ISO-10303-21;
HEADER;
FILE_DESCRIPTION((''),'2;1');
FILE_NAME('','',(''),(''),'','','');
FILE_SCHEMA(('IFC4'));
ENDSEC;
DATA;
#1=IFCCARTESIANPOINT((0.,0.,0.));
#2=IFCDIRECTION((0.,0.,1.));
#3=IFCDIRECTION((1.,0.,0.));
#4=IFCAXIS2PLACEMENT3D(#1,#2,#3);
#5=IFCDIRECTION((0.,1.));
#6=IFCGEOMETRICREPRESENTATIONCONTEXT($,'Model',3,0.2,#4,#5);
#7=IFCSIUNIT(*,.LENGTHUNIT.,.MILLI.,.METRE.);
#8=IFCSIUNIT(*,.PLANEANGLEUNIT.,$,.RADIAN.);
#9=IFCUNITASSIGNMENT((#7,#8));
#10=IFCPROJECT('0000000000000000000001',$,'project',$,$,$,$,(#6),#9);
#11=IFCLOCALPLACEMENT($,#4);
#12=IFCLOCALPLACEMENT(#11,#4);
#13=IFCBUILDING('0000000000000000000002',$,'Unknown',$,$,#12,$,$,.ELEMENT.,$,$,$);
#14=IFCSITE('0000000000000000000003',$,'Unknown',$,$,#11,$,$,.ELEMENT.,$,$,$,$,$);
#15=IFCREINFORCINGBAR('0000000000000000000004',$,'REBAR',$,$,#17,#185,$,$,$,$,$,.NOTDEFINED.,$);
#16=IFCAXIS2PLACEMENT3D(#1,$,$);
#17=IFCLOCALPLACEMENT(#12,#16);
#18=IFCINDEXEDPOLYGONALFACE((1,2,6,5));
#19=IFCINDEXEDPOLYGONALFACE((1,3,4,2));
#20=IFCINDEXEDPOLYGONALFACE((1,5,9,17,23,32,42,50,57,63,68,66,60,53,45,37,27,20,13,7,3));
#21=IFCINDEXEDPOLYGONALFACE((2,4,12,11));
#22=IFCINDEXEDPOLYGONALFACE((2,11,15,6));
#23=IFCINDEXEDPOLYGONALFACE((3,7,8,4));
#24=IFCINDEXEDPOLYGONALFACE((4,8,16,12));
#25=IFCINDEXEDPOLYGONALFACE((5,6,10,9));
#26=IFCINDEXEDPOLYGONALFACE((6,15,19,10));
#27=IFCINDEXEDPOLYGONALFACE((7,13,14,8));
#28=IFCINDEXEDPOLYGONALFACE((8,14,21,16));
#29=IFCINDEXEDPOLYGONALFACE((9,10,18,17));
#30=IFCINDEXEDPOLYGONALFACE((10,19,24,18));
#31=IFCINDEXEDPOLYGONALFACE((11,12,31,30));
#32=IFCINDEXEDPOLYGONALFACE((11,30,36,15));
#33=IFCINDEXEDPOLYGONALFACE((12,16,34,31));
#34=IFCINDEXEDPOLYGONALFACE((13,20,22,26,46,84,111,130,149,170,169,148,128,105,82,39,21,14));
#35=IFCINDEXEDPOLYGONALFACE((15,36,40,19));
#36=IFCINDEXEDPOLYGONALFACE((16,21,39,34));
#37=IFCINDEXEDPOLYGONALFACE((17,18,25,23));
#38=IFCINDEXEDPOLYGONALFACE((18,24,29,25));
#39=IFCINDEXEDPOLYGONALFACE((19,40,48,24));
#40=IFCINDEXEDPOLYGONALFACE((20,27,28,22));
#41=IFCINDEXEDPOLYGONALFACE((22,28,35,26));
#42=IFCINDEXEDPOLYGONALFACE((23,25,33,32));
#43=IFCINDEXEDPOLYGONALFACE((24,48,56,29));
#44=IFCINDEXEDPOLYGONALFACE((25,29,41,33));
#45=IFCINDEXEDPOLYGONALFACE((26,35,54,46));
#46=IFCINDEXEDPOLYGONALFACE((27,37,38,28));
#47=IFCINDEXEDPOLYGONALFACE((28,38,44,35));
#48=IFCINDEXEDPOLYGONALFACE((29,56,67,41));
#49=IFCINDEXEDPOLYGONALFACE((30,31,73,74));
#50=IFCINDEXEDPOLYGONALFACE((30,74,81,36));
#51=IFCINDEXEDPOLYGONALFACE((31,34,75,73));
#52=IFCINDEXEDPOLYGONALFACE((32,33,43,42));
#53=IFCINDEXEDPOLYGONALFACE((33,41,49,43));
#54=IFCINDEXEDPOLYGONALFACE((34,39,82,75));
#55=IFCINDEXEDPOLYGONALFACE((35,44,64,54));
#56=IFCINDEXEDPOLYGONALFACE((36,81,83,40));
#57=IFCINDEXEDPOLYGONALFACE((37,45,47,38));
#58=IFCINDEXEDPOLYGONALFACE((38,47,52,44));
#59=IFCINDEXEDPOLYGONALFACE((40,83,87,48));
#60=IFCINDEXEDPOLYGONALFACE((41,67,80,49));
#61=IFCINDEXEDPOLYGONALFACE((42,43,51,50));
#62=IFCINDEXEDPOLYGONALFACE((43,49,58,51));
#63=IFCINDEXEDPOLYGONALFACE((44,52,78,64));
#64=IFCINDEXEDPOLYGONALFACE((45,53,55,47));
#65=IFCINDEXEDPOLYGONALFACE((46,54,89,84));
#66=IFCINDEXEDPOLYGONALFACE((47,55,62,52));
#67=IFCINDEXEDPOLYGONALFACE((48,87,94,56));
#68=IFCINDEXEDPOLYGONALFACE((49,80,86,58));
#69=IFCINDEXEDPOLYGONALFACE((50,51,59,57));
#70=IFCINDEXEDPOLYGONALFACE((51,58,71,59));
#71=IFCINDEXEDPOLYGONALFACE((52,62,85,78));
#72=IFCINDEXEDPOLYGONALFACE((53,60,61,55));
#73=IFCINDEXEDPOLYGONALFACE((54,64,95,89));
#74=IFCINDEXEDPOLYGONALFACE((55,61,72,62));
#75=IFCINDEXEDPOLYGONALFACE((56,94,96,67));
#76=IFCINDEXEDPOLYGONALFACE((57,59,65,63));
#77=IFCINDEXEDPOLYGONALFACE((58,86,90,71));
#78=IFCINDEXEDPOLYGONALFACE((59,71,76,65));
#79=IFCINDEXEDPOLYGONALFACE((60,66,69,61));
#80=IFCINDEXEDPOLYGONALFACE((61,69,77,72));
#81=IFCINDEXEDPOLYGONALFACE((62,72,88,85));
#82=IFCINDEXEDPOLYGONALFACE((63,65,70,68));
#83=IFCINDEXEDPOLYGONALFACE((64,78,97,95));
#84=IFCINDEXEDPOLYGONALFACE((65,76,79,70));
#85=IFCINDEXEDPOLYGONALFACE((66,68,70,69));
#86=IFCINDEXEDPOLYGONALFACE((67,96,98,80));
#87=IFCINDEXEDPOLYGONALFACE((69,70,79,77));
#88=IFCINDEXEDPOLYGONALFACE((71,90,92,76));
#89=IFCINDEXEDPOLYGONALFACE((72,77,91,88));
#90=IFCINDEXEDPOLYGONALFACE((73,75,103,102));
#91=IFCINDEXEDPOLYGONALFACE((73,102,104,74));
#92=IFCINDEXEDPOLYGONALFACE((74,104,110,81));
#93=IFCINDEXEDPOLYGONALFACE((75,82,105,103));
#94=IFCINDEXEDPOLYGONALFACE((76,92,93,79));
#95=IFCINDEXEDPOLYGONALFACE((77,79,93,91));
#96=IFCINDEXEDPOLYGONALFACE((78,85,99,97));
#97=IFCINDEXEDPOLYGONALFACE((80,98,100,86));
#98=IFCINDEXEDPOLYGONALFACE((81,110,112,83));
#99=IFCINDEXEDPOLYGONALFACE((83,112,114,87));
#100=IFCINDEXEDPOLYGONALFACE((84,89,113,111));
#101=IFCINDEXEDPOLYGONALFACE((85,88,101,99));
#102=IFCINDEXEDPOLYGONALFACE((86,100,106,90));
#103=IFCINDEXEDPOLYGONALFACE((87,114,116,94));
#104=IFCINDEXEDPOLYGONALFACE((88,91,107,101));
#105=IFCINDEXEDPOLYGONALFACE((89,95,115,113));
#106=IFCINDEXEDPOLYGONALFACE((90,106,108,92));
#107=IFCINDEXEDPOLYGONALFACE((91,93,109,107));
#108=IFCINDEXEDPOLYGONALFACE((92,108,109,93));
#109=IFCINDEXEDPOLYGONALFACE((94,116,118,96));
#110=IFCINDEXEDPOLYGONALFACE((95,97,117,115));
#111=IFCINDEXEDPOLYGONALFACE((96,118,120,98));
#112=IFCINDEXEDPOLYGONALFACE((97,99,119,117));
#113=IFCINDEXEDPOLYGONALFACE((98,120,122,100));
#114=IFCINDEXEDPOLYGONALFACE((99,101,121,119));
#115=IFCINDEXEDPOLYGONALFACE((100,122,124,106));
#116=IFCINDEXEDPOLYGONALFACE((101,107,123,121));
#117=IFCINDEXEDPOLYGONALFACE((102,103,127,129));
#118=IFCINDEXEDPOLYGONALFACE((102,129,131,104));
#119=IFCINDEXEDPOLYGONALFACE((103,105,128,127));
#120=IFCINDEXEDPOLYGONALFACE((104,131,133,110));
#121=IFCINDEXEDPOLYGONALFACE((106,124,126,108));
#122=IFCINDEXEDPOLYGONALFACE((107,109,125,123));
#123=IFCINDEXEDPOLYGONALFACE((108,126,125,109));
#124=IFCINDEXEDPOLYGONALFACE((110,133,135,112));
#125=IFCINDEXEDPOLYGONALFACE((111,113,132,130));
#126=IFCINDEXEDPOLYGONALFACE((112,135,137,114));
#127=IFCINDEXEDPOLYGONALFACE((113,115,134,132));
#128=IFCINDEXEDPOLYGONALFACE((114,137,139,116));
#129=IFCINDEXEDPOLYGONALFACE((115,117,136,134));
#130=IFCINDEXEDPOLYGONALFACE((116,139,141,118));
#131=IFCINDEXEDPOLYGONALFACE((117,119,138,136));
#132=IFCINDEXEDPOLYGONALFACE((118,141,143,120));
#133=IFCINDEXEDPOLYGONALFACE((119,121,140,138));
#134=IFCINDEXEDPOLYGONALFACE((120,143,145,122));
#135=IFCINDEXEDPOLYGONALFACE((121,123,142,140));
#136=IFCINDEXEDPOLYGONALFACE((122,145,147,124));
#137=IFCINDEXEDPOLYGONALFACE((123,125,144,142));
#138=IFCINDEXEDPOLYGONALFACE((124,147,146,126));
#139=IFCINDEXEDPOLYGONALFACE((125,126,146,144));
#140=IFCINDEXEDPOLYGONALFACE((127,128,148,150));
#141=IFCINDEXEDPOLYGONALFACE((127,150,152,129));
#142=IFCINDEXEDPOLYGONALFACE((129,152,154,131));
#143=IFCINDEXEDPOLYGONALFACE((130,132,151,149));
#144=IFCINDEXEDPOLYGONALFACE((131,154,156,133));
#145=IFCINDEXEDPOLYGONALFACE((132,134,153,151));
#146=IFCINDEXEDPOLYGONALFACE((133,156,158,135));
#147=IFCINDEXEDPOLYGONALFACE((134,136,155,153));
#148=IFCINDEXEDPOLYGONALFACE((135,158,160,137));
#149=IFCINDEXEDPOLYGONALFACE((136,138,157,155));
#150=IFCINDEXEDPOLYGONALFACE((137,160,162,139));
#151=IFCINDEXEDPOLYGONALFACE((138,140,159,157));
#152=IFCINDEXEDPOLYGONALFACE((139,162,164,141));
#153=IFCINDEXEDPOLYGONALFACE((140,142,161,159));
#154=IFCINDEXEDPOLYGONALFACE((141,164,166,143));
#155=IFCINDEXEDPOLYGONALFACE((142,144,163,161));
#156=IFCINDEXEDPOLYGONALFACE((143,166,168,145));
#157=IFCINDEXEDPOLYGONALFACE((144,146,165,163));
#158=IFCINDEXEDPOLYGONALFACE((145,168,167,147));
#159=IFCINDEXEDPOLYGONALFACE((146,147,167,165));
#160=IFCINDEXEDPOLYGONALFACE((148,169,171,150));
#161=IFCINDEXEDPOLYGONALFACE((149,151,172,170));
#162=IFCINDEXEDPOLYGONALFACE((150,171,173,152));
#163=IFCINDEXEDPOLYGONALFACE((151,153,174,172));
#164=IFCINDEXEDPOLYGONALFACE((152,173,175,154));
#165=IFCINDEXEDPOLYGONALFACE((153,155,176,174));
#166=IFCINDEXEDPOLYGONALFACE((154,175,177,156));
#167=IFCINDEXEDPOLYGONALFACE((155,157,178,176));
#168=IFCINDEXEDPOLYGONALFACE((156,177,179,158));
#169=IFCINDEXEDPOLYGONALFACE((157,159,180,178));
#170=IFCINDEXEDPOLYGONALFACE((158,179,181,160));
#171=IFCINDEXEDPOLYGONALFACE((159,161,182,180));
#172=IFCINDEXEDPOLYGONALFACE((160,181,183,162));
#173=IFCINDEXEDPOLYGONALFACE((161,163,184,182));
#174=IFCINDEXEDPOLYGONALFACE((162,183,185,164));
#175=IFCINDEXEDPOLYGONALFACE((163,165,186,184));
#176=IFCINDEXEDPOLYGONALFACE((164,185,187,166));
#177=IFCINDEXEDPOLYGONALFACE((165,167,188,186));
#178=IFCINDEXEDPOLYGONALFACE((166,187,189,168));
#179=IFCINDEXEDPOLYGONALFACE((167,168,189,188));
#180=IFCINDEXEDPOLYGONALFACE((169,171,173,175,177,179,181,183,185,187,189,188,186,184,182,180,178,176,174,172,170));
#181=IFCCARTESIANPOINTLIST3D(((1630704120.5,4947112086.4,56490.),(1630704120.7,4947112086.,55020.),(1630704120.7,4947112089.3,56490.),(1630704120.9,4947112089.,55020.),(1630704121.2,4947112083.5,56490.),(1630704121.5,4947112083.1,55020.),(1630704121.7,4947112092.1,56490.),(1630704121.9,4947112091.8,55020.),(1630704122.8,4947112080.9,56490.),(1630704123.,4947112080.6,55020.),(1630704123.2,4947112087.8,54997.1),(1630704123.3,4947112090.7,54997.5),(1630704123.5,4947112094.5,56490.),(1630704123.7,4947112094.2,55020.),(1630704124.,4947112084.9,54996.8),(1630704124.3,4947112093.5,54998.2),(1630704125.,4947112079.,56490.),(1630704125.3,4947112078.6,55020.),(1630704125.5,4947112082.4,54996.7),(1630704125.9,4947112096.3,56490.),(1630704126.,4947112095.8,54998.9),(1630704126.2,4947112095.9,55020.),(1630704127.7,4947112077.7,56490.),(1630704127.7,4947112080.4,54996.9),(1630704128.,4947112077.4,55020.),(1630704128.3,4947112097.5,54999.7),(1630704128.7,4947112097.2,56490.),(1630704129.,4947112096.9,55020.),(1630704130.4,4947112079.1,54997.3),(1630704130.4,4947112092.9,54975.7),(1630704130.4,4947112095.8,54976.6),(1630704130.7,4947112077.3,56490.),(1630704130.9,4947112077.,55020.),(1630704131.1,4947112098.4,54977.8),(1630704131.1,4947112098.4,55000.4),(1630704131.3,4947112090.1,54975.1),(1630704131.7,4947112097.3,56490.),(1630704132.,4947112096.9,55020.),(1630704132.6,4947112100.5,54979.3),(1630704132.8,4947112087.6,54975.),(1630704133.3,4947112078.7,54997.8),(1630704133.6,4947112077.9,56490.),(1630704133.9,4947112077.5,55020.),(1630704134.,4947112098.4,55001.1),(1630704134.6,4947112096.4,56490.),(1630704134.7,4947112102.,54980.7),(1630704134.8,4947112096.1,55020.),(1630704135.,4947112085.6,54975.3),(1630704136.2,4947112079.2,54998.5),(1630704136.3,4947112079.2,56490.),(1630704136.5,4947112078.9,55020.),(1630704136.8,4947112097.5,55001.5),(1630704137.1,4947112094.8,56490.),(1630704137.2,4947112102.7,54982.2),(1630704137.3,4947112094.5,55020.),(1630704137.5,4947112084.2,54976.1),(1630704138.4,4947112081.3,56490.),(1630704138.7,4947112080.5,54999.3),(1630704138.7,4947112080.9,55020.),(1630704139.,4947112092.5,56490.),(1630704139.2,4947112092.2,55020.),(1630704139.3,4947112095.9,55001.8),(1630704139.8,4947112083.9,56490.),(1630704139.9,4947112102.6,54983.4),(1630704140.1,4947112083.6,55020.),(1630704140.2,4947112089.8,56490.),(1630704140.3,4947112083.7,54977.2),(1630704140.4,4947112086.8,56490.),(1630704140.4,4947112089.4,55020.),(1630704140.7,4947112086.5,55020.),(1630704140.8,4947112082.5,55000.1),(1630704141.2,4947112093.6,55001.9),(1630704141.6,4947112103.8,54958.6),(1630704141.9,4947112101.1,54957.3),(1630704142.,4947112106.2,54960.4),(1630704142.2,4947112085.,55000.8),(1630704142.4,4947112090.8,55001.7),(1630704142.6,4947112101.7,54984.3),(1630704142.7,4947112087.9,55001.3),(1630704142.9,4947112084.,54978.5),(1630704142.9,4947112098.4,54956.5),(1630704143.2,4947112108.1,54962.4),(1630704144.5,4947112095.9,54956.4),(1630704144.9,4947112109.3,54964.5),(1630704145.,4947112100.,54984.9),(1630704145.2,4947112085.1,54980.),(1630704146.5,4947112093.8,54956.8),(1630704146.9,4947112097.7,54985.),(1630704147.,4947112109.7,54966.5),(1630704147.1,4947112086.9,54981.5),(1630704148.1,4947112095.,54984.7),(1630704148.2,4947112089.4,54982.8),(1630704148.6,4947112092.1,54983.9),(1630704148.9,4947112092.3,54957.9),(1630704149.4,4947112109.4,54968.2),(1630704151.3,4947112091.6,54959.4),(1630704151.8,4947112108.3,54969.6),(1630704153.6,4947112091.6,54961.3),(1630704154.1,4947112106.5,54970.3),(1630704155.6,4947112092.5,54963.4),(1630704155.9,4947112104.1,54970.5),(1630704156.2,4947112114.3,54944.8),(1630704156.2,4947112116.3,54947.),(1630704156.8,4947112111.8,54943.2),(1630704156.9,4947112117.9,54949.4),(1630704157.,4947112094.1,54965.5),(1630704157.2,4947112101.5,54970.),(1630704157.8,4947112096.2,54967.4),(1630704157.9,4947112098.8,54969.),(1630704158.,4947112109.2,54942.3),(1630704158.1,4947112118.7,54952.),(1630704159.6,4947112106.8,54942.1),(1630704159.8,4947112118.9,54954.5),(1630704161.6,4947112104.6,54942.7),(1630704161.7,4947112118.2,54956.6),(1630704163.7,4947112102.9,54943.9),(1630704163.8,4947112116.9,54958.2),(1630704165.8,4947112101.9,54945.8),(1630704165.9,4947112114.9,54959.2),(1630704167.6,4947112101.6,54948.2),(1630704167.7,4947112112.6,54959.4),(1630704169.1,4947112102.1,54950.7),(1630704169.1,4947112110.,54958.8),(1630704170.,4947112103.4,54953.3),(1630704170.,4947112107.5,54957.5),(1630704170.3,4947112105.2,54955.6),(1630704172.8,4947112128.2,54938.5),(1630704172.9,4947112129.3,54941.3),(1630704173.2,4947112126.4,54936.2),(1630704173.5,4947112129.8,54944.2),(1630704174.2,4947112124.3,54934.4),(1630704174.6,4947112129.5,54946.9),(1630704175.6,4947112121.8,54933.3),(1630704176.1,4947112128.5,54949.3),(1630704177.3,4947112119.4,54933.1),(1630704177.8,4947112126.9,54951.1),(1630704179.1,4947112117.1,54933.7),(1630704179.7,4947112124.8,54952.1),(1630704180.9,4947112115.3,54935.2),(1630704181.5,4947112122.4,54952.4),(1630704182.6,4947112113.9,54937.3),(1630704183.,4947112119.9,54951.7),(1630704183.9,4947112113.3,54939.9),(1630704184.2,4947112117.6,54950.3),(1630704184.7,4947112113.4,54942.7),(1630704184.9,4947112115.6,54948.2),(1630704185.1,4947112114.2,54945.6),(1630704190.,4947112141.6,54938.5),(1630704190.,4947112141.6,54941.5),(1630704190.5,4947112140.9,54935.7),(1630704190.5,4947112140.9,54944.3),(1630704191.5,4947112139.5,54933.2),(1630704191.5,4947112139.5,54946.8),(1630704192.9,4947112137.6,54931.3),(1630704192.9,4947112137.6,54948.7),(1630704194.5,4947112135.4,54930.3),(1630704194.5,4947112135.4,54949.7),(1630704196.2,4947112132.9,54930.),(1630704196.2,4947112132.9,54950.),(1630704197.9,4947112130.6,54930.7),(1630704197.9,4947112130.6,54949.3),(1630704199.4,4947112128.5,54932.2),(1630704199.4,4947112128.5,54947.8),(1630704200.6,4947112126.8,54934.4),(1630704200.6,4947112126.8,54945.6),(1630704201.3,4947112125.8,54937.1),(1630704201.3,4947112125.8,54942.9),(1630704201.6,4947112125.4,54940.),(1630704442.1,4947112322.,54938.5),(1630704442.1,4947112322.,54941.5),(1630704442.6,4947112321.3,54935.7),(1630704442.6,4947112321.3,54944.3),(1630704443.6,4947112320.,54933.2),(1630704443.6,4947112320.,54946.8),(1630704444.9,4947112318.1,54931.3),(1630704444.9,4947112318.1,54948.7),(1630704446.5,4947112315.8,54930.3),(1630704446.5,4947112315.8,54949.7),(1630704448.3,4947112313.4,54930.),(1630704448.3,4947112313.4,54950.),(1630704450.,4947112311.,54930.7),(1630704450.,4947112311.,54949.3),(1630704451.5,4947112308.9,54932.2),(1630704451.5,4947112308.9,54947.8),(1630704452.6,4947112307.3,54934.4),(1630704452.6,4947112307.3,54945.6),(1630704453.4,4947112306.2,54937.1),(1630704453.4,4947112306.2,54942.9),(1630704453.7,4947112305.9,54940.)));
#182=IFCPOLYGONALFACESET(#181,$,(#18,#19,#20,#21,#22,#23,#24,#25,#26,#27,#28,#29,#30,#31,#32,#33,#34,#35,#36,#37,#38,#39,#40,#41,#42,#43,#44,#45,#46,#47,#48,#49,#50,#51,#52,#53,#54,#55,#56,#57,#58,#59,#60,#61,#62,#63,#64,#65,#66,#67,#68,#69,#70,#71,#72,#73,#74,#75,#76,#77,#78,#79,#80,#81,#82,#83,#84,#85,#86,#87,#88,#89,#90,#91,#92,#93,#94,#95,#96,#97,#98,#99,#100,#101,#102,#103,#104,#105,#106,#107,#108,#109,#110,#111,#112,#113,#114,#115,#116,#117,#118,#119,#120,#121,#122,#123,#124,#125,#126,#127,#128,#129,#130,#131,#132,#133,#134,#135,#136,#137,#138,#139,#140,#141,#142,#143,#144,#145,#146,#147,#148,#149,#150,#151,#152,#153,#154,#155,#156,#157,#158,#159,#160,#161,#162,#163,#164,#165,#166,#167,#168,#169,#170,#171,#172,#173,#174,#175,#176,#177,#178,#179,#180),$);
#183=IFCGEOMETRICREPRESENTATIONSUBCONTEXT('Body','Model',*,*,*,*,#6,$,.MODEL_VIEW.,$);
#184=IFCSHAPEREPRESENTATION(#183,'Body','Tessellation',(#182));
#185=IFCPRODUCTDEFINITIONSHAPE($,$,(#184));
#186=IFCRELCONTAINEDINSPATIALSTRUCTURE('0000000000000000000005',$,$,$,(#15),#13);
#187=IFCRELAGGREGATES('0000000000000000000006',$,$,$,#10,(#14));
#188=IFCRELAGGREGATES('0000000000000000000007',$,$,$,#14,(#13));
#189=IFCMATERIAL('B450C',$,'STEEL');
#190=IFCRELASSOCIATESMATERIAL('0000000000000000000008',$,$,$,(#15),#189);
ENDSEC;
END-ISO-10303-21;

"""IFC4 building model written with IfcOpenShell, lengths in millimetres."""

from ifc_helpers import new_model, entity, si_unit, direction, frame, origin_with_axes, place, context, subcontext, project, spatial, material, element, save


model = new_model("IFC4")

# Units and contexts
model_context = context("Model", 3, precision=0.2, world=origin_with_axes(), true_north=direction((0.0, 1.0)))
body_context = subcontext(model_context, "Body", "Model", "MODEL_VIEW")
ifc_project = project(units=[si_unit("LENGTHUNIT", "METRE", prefix="MILLI"), si_unit("PLANEANGLEUNIT", "RADIAN")], contexts=[model_context])

# Site, building
site_placement = place(None, origin_with_axes())
site = spatial("IfcSite", under=ifc_project, at=site_placement, Name="Unknown", CompositionType="ELEMENT")
building_placement = place(site_placement, origin_with_axes())
building = spatial("IfcBuilding", under=site, at=building_placement, Name="Unknown", CompositionType="ELEMENT")

# Reinforcing bar
ifc_material = material(Name="B450C", Category="STEEL")
reinforcing_bar_1_placement = place(building_placement, frame((1630704060.9, 4947112098.5, 54890.0), z_axis=(0.582364, -0.812928, 0.0), x_axis=(0.0, 0.0, 1.0)))
element("IfcReinforcingBar", 1, at=reinforcing_bar_1_placement, inside=building, material=ifc_material, Name="REBAR", PredefinedType="NOTDEFINED", context=body_context, shape_type="AdvancedSweptSolid", body=[
    entity("IfcSweptDiskSolid", entity("IfcIndexedPolyCurve", entity("IfcCartesianPointList3D", [[50.0, -440.0, 50.1], [50.0, -130.0, 50.0], [73.4, -73.4, 50.0], [130.0, -50.0, 50.0], [1600.0, -50.0, 49.6]]), [entity("IfcLineIndex", [1, 2]), entity("IfcArcIndex", [2, 3, 4]), entity("IfcLineIndex", [4, 5])]), 10.0),
])

save(model, "model.ifc")
